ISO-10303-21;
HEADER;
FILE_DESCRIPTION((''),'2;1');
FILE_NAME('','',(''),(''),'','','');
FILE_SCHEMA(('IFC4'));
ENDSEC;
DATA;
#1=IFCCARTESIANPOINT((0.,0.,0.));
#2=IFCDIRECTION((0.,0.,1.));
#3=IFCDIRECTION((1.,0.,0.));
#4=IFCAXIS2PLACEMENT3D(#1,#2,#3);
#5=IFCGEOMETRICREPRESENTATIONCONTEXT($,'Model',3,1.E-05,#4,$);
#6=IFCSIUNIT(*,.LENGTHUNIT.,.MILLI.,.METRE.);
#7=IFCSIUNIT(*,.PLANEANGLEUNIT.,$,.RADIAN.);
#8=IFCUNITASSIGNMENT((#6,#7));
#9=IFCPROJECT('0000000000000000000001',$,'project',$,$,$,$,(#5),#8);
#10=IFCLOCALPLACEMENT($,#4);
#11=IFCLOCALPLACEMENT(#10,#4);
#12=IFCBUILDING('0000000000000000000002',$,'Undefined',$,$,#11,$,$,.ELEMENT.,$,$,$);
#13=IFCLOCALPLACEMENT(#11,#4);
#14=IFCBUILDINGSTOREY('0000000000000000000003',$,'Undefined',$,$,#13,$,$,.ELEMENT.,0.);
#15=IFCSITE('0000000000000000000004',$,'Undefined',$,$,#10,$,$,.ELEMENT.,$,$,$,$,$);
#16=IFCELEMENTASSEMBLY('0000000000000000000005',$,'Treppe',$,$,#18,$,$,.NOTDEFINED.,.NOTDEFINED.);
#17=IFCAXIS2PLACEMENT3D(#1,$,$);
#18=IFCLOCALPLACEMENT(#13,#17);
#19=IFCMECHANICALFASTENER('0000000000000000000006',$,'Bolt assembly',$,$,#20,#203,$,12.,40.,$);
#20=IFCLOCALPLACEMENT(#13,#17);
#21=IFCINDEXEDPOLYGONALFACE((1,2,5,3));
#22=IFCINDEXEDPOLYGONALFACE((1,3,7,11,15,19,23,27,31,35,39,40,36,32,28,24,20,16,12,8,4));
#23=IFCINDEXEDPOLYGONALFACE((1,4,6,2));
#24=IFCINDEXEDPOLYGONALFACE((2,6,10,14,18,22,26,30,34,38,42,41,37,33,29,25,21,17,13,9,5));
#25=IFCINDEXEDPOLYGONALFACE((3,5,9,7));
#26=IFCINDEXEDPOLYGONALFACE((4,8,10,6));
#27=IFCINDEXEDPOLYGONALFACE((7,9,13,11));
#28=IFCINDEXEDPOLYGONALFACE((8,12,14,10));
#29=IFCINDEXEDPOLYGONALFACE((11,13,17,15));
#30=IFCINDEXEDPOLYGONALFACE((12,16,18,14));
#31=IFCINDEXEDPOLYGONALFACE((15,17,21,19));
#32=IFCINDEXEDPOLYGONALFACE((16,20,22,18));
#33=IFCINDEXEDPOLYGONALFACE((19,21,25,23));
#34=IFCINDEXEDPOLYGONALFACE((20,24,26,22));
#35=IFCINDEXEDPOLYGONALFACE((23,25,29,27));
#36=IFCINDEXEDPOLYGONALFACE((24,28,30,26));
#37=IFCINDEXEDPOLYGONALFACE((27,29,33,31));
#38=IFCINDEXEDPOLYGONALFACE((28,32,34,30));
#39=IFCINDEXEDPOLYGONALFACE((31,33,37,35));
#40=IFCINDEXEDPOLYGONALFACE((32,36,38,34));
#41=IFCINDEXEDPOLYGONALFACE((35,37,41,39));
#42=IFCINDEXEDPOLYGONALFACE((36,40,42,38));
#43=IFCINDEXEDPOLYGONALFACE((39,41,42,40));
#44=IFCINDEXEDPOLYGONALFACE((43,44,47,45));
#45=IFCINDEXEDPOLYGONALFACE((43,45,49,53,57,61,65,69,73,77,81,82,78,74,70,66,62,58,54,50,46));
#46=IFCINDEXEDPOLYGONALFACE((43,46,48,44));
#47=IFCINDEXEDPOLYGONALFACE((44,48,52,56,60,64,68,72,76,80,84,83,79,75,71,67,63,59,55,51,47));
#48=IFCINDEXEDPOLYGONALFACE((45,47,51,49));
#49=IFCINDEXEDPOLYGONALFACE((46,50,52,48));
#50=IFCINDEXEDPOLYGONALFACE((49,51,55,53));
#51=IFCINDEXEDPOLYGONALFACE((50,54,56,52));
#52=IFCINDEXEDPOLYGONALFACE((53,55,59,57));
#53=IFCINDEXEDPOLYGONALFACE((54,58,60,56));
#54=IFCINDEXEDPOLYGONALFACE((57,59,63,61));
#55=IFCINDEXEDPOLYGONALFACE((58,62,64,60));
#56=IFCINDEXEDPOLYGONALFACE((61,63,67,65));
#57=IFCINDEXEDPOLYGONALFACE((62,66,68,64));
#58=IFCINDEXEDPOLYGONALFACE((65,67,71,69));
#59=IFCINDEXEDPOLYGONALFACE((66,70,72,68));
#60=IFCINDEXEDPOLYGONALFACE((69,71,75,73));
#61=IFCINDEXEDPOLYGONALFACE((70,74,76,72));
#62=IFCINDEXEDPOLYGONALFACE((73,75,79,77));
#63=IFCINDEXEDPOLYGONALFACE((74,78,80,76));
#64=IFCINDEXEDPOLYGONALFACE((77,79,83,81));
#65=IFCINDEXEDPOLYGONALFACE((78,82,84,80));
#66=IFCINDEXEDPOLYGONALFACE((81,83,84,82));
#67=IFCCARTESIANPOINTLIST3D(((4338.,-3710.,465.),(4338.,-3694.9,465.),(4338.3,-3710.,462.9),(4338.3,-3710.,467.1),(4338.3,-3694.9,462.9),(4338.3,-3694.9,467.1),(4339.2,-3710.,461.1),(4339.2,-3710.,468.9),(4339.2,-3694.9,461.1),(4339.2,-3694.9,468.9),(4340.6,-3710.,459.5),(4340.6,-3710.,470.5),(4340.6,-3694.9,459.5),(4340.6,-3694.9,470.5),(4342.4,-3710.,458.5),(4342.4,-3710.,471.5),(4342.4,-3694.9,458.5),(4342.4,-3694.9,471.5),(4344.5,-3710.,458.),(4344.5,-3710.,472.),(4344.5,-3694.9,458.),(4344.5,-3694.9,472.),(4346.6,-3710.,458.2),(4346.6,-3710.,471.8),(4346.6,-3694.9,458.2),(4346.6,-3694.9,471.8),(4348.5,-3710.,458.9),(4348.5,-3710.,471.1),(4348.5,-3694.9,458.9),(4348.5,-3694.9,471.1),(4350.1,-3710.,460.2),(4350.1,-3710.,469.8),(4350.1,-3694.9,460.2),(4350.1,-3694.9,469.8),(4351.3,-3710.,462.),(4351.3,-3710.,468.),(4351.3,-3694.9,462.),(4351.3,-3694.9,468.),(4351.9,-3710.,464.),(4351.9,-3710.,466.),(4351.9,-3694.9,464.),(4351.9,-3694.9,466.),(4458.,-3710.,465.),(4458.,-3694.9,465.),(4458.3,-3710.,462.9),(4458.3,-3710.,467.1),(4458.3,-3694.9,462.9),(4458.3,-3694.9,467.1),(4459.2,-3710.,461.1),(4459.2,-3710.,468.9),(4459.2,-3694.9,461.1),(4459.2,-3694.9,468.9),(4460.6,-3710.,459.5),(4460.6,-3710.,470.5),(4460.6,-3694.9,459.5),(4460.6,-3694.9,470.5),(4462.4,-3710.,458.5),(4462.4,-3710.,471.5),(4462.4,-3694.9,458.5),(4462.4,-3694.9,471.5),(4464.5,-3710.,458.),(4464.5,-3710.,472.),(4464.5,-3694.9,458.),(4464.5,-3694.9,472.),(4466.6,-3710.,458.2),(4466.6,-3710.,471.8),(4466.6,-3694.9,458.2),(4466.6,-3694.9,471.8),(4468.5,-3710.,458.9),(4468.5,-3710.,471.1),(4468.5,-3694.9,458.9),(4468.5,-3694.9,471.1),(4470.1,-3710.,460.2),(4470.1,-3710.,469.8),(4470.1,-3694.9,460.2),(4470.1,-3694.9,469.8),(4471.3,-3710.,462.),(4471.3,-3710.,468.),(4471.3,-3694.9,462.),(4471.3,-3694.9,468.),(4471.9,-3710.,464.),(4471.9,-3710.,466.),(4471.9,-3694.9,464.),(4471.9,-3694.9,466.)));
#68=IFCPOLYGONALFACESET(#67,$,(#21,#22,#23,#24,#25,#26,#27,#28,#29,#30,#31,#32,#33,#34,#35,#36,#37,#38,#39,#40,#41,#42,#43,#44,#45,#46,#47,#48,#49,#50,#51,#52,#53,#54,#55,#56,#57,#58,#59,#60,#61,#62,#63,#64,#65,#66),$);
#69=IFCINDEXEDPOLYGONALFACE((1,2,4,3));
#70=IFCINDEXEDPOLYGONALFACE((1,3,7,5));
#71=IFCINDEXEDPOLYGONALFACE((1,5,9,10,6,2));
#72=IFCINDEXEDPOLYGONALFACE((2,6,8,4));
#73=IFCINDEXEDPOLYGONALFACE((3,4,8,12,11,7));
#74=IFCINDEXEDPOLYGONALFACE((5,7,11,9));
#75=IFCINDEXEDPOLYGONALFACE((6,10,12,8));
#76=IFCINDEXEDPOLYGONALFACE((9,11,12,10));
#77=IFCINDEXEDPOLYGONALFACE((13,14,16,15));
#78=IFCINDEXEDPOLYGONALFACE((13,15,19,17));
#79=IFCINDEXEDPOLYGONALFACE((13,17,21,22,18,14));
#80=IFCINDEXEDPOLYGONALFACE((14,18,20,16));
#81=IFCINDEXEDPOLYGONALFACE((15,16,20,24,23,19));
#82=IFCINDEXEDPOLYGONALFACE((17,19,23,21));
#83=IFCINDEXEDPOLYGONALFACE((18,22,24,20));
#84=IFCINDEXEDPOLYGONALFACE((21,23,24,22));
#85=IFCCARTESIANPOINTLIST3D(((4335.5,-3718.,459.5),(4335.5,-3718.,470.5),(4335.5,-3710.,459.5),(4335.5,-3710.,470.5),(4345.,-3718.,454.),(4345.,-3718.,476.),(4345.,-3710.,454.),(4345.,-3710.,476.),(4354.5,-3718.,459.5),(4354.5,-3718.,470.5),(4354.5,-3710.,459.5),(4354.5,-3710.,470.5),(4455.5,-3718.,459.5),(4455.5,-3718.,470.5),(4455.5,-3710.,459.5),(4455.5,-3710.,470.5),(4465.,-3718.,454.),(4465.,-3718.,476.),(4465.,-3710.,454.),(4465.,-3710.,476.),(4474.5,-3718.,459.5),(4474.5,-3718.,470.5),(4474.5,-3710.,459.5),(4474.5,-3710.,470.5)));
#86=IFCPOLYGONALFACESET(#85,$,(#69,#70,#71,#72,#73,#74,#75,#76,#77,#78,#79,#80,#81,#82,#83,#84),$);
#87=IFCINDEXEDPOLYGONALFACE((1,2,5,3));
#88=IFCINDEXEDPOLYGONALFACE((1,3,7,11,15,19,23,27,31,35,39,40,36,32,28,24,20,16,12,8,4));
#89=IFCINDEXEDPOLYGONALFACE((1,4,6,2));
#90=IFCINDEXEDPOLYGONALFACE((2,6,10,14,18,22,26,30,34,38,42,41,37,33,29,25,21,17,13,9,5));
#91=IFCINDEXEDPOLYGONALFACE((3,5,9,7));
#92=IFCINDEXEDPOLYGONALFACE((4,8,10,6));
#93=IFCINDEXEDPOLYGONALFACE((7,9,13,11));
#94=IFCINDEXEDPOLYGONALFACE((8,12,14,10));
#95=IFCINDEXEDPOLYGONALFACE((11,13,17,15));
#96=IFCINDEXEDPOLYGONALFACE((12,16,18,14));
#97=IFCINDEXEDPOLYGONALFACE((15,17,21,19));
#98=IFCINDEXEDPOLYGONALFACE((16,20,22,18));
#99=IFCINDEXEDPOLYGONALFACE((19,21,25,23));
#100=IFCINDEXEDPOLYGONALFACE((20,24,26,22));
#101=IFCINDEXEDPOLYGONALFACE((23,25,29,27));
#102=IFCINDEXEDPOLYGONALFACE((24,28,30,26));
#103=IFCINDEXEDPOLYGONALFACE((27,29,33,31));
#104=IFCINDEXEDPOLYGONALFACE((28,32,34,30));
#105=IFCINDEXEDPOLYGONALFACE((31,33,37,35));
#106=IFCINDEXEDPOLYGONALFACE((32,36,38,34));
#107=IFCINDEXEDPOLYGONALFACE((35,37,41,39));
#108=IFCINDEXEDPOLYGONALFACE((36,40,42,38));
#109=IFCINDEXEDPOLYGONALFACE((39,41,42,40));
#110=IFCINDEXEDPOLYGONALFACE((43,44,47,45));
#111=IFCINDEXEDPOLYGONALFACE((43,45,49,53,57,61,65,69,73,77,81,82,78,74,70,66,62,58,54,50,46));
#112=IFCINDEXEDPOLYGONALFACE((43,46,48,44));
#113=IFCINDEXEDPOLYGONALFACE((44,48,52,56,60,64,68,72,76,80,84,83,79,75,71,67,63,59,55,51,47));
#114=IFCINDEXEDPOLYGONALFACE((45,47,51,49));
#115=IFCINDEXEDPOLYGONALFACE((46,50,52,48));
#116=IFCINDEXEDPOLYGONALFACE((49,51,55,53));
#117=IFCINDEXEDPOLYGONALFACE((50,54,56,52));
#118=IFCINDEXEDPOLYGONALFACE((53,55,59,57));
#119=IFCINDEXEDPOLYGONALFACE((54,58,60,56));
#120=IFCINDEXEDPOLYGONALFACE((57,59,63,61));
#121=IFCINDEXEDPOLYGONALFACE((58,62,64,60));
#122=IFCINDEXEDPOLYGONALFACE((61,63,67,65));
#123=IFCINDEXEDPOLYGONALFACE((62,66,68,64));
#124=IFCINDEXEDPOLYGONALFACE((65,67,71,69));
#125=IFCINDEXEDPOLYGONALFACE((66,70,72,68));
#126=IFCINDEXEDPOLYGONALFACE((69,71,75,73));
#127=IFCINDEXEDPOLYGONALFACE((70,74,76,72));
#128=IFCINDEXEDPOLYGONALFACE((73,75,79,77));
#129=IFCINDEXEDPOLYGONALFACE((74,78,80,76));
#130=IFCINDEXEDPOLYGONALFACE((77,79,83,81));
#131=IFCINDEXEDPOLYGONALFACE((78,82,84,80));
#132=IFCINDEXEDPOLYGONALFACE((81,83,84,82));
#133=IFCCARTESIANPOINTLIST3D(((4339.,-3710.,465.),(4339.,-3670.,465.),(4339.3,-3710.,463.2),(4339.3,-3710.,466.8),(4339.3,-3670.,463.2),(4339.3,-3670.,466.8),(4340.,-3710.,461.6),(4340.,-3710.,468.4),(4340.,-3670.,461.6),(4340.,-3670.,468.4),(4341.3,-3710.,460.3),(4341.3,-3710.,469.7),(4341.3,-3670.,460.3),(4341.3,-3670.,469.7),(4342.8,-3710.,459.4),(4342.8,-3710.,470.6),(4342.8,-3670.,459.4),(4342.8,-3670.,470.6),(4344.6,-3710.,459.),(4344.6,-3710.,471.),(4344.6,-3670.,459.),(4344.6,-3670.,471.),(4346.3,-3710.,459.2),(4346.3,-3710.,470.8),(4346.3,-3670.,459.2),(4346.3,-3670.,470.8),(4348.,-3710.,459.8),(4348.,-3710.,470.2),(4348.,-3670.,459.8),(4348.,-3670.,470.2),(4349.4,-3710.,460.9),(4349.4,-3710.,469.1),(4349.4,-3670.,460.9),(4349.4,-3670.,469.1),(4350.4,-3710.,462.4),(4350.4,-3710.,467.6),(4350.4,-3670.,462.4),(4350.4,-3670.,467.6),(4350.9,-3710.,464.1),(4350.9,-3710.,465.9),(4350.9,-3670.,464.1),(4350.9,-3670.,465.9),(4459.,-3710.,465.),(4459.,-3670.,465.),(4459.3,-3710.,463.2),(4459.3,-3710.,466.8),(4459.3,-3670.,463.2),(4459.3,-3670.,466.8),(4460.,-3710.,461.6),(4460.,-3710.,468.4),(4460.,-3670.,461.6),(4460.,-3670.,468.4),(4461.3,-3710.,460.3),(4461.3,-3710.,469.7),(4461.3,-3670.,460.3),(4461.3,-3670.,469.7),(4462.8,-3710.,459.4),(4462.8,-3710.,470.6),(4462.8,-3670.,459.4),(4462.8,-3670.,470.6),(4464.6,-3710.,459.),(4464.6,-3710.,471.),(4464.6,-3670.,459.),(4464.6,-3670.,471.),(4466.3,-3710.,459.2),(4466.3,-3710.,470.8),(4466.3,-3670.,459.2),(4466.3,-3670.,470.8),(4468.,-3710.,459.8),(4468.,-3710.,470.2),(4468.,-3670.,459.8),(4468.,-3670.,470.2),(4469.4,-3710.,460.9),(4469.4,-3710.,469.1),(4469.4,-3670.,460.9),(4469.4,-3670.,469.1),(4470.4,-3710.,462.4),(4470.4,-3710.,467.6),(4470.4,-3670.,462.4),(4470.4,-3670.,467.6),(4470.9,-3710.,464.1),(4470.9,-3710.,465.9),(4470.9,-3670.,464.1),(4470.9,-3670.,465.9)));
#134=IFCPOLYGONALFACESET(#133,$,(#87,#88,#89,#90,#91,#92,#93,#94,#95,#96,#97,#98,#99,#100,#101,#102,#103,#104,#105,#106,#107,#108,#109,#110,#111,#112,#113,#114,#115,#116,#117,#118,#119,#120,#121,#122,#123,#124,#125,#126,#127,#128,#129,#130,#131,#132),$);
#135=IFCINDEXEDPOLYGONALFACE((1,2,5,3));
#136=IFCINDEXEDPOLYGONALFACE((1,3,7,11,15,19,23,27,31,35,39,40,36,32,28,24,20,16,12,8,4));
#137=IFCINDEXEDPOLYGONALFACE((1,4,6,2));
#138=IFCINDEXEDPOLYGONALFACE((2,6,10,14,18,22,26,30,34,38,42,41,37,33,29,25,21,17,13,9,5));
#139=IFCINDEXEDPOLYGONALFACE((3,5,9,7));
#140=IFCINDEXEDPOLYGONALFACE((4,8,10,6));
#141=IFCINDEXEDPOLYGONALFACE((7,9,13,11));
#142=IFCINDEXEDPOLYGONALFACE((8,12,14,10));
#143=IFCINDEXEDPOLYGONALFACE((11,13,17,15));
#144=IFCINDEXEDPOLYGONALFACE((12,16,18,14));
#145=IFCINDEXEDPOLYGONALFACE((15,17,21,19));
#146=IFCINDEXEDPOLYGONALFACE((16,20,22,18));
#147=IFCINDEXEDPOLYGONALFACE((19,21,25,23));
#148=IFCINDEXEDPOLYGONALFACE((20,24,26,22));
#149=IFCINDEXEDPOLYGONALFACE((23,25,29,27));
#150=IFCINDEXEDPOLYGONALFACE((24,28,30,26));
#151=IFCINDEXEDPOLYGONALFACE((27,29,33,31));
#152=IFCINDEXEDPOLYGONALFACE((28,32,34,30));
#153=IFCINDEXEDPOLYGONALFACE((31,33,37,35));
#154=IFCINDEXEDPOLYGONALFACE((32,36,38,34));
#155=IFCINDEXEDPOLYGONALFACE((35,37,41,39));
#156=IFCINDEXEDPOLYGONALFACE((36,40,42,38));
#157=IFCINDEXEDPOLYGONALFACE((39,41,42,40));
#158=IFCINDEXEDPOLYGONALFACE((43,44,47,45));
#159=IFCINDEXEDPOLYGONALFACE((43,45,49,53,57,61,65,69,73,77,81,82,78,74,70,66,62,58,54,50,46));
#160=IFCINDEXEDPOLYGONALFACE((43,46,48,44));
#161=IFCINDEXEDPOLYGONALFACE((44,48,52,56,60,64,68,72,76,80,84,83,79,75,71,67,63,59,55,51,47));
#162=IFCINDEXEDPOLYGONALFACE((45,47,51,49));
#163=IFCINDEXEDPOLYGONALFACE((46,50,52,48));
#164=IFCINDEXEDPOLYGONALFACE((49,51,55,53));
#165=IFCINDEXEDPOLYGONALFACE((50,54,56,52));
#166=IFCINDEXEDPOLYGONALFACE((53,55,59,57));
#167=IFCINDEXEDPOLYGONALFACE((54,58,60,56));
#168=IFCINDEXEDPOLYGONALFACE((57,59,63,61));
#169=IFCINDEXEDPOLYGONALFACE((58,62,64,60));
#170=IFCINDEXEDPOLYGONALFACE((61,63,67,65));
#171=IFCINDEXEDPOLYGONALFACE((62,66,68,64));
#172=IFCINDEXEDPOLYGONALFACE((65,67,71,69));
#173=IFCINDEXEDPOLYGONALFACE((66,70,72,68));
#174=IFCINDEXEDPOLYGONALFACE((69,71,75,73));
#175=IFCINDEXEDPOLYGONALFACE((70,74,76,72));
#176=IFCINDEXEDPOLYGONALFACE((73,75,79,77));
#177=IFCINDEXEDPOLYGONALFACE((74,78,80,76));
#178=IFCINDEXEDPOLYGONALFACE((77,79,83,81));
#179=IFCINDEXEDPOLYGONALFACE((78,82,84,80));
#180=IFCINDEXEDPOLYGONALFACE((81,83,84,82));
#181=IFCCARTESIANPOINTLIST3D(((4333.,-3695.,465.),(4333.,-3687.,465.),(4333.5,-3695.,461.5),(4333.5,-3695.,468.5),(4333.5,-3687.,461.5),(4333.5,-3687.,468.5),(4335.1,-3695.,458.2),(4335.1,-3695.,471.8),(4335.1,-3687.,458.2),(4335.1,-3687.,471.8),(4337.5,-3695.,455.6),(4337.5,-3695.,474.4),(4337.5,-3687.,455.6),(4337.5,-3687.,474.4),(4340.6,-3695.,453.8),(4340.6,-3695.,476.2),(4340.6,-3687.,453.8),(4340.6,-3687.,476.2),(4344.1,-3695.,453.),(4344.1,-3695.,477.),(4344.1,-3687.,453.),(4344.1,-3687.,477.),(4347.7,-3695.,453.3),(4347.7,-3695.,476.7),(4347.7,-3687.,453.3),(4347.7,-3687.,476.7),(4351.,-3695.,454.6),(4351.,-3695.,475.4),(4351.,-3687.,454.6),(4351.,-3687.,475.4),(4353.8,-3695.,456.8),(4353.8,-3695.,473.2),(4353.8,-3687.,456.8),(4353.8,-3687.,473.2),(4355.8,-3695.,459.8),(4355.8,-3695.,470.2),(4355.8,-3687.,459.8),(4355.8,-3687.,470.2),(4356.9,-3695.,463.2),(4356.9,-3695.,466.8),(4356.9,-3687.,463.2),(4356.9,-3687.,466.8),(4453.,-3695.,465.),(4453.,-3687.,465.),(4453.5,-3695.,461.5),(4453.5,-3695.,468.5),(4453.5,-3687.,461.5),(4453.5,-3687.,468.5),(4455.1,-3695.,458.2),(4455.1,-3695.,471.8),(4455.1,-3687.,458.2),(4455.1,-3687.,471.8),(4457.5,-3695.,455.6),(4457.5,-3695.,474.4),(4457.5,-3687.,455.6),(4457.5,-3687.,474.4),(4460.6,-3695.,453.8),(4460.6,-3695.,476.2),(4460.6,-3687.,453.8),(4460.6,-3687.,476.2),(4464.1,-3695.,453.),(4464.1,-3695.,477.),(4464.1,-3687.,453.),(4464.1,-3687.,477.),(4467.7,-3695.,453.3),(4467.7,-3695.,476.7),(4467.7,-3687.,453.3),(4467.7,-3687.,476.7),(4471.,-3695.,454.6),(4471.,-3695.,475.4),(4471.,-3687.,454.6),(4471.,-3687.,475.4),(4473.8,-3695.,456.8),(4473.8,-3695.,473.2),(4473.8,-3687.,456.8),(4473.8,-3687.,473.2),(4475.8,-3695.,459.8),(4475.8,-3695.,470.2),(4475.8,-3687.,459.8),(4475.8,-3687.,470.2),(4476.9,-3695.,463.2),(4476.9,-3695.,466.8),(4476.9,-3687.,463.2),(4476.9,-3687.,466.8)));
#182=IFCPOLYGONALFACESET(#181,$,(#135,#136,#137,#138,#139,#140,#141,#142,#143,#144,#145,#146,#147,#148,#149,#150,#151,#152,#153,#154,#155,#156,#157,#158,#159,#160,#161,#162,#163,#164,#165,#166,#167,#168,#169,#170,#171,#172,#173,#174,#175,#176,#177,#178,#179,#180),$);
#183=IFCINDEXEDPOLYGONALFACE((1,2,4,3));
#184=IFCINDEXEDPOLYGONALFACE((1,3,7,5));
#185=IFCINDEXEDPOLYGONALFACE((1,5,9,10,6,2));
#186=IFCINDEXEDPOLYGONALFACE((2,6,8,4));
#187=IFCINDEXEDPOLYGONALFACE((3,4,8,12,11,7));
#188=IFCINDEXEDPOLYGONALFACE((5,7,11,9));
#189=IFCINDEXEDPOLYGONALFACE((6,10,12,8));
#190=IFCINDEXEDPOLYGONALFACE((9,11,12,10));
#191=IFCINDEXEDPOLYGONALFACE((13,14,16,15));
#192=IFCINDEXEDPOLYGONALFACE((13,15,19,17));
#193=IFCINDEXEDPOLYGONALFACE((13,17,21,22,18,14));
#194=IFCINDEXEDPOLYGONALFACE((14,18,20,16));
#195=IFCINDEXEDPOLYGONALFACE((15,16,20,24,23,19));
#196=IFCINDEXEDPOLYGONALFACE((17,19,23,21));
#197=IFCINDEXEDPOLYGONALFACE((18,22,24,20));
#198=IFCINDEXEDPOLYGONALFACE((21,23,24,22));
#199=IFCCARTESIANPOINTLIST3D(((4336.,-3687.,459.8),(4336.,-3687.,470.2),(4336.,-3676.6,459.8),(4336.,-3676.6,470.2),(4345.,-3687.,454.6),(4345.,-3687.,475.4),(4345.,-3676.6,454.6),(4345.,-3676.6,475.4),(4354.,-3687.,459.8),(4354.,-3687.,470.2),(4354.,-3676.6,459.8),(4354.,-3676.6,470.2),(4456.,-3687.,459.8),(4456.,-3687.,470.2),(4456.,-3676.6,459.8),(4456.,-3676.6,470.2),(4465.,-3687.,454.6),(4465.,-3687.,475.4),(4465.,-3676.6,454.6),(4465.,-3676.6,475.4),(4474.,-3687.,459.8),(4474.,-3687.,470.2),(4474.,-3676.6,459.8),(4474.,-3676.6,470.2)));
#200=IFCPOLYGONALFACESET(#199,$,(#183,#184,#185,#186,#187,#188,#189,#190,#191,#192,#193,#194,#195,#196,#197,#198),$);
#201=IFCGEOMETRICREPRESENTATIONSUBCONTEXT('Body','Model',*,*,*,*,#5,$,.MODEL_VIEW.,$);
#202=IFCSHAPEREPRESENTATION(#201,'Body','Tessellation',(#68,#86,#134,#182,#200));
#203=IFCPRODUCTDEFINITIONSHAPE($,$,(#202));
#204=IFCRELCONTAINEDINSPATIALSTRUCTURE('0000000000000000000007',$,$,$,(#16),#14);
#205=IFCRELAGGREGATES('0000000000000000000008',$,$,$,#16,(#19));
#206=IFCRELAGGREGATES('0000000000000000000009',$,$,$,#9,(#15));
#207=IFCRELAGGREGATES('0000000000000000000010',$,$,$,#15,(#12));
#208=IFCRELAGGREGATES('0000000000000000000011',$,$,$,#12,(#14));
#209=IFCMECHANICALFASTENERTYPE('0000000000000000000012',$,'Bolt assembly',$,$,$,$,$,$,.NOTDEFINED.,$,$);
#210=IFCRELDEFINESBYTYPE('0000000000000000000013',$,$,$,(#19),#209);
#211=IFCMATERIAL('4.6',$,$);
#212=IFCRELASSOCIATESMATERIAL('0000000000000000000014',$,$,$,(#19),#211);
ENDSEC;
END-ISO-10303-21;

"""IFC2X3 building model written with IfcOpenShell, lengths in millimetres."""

from ifc_helpers import new_model, si_unit, frame, origin_with_axes, origin_2d_with_axis, place, context, subcontext, project, spatial, polyline, circle, outline, extrude, source, transform, mapped, material, type_object, element, aggregate, save


model = new_model("IFC2X3")

# Units and contexts
model_context = context("Model", 3, precision=1e-05, world=origin_with_axes())
body_context = subcontext(model_context, "Body", "Model", "MODEL_VIEW")
ifc_project = project(units=[si_unit("LENGTHUNIT", "METRE", prefix="MILLI"), si_unit("PLANEANGLEUNIT", "RADIAN")], contexts=[model_context])

# Site, building, storey
site_placement = place(None, origin_with_axes())
site = spatial("IfcSite", under=ifc_project, at=site_placement, Name="Undefined", CompositionType="ELEMENT")
building_placement = place(site_placement, origin_with_axes())
building = spatial("IfcBuilding", under=site, at=building_placement, Name="Undefined", CompositionType="ELEMENT")
storey_placement = place(building_placement, origin_with_axes())
storey = spatial("IfcBuildingStorey", under=building, at=storey_placement, Name="Undefined", CompositionType="ELEMENT", Elevation=0.0)

# Element assembly
assembly_1_placement = place(storey_placement, origin_with_axes())
assembly_1 = element("IfcElementAssembly", 1, at=assembly_1_placement, inside=storey, Name="Treppe", AssemblyPlace="NOTDEFINED", PredefinedType="NOTDEFINED")

# Mechanical fastener
ifc_material_1 = material(Name="4.6")
mechanical_fastener_type = type_object("IfcMechanicalFastenerType", Name="Bolt assembly")
shared_shape_1 = source(origin_with_axes(), body_context, "Body", "SweptSolid", [
    extrude(circle(Radius=7.0, at=origin_2d_with_axis()), frame((0.0, 0.0, 0.0), z_axis=(0.0, 1.0, 0.0), x_axis=(1.0, 0.0, 0.0)), (0.0, 0.0, 1.0), 15.1),
    extrude(outline(polyline([(9.5, -5.5), (9.5, 5.5), (0.0, 11.0), (-9.5, 5.5), (-9.5, -5.5), (0.0, -11.0), (9.5, -5.5)])), frame((0.0, -8.0, 0.0), z_axis=(0.0, 1.0, 0.0), x_axis=(1.0, 0.0, 0.0)), (0.0, 0.0, 1.0), 8.0),
    extrude(circle(Radius=6.0, at=origin_2d_with_axis()), frame((0.0, 0.0, 0.0), z_axis=(0.0, 1.0, 0.0), x_axis=(1.0, 0.0, 0.0)), (0.0, 0.0, 1.0), 40.0),
    extrude(circle(Radius=12.0, at=origin_2d_with_axis()), frame((0.0, 15.0, 0.0), z_axis=(0.0, 1.0, 0.0), x_axis=(1.0, 0.0, 0.0)), (0.0, 0.0, 1.0), 8.0),
    extrude(outline(polyline([(9.0, -5.2), (9.0, 5.2), (0.0, 10.4), (-9.0, 5.2), (-9.0, -5.2), (0.0, -10.4), (9.0, -5.2)])), frame((0.0, 23.0, 0.0), z_axis=(0.0, 1.0, 0.0), x_axis=(1.0, 0.0, 0.0)), (0.0, 0.0, 1.0), 10.4),
])
mechanical_fastener_1_placement = place(assembly_1_placement, frame((4465.0, -3710.0, 465.0), z_axis=(0.0, 0.0, -1.0), x_axis=(-1.0, 0.0, 0.0)))
mechanical_fastener_1 = element("IfcMechanicalFastener", 2, at=mechanical_fastener_1_placement, type_object=mechanical_fastener_type, material=ifc_material_1, Name="Bolt assembly", NominalDiameter=12.0, NominalLength=40.0, context=body_context, shape_type="MappedRepresentation", body=[
    mapped(shared_shape_1, transform((0.0, 0.0, 0.0))),
    mapped(shared_shape_1, transform((120.0, 0.0, 0.0))),
])
aggregate(assembly_1, [mechanical_fastener_1])

save(model, "model.ifc")
